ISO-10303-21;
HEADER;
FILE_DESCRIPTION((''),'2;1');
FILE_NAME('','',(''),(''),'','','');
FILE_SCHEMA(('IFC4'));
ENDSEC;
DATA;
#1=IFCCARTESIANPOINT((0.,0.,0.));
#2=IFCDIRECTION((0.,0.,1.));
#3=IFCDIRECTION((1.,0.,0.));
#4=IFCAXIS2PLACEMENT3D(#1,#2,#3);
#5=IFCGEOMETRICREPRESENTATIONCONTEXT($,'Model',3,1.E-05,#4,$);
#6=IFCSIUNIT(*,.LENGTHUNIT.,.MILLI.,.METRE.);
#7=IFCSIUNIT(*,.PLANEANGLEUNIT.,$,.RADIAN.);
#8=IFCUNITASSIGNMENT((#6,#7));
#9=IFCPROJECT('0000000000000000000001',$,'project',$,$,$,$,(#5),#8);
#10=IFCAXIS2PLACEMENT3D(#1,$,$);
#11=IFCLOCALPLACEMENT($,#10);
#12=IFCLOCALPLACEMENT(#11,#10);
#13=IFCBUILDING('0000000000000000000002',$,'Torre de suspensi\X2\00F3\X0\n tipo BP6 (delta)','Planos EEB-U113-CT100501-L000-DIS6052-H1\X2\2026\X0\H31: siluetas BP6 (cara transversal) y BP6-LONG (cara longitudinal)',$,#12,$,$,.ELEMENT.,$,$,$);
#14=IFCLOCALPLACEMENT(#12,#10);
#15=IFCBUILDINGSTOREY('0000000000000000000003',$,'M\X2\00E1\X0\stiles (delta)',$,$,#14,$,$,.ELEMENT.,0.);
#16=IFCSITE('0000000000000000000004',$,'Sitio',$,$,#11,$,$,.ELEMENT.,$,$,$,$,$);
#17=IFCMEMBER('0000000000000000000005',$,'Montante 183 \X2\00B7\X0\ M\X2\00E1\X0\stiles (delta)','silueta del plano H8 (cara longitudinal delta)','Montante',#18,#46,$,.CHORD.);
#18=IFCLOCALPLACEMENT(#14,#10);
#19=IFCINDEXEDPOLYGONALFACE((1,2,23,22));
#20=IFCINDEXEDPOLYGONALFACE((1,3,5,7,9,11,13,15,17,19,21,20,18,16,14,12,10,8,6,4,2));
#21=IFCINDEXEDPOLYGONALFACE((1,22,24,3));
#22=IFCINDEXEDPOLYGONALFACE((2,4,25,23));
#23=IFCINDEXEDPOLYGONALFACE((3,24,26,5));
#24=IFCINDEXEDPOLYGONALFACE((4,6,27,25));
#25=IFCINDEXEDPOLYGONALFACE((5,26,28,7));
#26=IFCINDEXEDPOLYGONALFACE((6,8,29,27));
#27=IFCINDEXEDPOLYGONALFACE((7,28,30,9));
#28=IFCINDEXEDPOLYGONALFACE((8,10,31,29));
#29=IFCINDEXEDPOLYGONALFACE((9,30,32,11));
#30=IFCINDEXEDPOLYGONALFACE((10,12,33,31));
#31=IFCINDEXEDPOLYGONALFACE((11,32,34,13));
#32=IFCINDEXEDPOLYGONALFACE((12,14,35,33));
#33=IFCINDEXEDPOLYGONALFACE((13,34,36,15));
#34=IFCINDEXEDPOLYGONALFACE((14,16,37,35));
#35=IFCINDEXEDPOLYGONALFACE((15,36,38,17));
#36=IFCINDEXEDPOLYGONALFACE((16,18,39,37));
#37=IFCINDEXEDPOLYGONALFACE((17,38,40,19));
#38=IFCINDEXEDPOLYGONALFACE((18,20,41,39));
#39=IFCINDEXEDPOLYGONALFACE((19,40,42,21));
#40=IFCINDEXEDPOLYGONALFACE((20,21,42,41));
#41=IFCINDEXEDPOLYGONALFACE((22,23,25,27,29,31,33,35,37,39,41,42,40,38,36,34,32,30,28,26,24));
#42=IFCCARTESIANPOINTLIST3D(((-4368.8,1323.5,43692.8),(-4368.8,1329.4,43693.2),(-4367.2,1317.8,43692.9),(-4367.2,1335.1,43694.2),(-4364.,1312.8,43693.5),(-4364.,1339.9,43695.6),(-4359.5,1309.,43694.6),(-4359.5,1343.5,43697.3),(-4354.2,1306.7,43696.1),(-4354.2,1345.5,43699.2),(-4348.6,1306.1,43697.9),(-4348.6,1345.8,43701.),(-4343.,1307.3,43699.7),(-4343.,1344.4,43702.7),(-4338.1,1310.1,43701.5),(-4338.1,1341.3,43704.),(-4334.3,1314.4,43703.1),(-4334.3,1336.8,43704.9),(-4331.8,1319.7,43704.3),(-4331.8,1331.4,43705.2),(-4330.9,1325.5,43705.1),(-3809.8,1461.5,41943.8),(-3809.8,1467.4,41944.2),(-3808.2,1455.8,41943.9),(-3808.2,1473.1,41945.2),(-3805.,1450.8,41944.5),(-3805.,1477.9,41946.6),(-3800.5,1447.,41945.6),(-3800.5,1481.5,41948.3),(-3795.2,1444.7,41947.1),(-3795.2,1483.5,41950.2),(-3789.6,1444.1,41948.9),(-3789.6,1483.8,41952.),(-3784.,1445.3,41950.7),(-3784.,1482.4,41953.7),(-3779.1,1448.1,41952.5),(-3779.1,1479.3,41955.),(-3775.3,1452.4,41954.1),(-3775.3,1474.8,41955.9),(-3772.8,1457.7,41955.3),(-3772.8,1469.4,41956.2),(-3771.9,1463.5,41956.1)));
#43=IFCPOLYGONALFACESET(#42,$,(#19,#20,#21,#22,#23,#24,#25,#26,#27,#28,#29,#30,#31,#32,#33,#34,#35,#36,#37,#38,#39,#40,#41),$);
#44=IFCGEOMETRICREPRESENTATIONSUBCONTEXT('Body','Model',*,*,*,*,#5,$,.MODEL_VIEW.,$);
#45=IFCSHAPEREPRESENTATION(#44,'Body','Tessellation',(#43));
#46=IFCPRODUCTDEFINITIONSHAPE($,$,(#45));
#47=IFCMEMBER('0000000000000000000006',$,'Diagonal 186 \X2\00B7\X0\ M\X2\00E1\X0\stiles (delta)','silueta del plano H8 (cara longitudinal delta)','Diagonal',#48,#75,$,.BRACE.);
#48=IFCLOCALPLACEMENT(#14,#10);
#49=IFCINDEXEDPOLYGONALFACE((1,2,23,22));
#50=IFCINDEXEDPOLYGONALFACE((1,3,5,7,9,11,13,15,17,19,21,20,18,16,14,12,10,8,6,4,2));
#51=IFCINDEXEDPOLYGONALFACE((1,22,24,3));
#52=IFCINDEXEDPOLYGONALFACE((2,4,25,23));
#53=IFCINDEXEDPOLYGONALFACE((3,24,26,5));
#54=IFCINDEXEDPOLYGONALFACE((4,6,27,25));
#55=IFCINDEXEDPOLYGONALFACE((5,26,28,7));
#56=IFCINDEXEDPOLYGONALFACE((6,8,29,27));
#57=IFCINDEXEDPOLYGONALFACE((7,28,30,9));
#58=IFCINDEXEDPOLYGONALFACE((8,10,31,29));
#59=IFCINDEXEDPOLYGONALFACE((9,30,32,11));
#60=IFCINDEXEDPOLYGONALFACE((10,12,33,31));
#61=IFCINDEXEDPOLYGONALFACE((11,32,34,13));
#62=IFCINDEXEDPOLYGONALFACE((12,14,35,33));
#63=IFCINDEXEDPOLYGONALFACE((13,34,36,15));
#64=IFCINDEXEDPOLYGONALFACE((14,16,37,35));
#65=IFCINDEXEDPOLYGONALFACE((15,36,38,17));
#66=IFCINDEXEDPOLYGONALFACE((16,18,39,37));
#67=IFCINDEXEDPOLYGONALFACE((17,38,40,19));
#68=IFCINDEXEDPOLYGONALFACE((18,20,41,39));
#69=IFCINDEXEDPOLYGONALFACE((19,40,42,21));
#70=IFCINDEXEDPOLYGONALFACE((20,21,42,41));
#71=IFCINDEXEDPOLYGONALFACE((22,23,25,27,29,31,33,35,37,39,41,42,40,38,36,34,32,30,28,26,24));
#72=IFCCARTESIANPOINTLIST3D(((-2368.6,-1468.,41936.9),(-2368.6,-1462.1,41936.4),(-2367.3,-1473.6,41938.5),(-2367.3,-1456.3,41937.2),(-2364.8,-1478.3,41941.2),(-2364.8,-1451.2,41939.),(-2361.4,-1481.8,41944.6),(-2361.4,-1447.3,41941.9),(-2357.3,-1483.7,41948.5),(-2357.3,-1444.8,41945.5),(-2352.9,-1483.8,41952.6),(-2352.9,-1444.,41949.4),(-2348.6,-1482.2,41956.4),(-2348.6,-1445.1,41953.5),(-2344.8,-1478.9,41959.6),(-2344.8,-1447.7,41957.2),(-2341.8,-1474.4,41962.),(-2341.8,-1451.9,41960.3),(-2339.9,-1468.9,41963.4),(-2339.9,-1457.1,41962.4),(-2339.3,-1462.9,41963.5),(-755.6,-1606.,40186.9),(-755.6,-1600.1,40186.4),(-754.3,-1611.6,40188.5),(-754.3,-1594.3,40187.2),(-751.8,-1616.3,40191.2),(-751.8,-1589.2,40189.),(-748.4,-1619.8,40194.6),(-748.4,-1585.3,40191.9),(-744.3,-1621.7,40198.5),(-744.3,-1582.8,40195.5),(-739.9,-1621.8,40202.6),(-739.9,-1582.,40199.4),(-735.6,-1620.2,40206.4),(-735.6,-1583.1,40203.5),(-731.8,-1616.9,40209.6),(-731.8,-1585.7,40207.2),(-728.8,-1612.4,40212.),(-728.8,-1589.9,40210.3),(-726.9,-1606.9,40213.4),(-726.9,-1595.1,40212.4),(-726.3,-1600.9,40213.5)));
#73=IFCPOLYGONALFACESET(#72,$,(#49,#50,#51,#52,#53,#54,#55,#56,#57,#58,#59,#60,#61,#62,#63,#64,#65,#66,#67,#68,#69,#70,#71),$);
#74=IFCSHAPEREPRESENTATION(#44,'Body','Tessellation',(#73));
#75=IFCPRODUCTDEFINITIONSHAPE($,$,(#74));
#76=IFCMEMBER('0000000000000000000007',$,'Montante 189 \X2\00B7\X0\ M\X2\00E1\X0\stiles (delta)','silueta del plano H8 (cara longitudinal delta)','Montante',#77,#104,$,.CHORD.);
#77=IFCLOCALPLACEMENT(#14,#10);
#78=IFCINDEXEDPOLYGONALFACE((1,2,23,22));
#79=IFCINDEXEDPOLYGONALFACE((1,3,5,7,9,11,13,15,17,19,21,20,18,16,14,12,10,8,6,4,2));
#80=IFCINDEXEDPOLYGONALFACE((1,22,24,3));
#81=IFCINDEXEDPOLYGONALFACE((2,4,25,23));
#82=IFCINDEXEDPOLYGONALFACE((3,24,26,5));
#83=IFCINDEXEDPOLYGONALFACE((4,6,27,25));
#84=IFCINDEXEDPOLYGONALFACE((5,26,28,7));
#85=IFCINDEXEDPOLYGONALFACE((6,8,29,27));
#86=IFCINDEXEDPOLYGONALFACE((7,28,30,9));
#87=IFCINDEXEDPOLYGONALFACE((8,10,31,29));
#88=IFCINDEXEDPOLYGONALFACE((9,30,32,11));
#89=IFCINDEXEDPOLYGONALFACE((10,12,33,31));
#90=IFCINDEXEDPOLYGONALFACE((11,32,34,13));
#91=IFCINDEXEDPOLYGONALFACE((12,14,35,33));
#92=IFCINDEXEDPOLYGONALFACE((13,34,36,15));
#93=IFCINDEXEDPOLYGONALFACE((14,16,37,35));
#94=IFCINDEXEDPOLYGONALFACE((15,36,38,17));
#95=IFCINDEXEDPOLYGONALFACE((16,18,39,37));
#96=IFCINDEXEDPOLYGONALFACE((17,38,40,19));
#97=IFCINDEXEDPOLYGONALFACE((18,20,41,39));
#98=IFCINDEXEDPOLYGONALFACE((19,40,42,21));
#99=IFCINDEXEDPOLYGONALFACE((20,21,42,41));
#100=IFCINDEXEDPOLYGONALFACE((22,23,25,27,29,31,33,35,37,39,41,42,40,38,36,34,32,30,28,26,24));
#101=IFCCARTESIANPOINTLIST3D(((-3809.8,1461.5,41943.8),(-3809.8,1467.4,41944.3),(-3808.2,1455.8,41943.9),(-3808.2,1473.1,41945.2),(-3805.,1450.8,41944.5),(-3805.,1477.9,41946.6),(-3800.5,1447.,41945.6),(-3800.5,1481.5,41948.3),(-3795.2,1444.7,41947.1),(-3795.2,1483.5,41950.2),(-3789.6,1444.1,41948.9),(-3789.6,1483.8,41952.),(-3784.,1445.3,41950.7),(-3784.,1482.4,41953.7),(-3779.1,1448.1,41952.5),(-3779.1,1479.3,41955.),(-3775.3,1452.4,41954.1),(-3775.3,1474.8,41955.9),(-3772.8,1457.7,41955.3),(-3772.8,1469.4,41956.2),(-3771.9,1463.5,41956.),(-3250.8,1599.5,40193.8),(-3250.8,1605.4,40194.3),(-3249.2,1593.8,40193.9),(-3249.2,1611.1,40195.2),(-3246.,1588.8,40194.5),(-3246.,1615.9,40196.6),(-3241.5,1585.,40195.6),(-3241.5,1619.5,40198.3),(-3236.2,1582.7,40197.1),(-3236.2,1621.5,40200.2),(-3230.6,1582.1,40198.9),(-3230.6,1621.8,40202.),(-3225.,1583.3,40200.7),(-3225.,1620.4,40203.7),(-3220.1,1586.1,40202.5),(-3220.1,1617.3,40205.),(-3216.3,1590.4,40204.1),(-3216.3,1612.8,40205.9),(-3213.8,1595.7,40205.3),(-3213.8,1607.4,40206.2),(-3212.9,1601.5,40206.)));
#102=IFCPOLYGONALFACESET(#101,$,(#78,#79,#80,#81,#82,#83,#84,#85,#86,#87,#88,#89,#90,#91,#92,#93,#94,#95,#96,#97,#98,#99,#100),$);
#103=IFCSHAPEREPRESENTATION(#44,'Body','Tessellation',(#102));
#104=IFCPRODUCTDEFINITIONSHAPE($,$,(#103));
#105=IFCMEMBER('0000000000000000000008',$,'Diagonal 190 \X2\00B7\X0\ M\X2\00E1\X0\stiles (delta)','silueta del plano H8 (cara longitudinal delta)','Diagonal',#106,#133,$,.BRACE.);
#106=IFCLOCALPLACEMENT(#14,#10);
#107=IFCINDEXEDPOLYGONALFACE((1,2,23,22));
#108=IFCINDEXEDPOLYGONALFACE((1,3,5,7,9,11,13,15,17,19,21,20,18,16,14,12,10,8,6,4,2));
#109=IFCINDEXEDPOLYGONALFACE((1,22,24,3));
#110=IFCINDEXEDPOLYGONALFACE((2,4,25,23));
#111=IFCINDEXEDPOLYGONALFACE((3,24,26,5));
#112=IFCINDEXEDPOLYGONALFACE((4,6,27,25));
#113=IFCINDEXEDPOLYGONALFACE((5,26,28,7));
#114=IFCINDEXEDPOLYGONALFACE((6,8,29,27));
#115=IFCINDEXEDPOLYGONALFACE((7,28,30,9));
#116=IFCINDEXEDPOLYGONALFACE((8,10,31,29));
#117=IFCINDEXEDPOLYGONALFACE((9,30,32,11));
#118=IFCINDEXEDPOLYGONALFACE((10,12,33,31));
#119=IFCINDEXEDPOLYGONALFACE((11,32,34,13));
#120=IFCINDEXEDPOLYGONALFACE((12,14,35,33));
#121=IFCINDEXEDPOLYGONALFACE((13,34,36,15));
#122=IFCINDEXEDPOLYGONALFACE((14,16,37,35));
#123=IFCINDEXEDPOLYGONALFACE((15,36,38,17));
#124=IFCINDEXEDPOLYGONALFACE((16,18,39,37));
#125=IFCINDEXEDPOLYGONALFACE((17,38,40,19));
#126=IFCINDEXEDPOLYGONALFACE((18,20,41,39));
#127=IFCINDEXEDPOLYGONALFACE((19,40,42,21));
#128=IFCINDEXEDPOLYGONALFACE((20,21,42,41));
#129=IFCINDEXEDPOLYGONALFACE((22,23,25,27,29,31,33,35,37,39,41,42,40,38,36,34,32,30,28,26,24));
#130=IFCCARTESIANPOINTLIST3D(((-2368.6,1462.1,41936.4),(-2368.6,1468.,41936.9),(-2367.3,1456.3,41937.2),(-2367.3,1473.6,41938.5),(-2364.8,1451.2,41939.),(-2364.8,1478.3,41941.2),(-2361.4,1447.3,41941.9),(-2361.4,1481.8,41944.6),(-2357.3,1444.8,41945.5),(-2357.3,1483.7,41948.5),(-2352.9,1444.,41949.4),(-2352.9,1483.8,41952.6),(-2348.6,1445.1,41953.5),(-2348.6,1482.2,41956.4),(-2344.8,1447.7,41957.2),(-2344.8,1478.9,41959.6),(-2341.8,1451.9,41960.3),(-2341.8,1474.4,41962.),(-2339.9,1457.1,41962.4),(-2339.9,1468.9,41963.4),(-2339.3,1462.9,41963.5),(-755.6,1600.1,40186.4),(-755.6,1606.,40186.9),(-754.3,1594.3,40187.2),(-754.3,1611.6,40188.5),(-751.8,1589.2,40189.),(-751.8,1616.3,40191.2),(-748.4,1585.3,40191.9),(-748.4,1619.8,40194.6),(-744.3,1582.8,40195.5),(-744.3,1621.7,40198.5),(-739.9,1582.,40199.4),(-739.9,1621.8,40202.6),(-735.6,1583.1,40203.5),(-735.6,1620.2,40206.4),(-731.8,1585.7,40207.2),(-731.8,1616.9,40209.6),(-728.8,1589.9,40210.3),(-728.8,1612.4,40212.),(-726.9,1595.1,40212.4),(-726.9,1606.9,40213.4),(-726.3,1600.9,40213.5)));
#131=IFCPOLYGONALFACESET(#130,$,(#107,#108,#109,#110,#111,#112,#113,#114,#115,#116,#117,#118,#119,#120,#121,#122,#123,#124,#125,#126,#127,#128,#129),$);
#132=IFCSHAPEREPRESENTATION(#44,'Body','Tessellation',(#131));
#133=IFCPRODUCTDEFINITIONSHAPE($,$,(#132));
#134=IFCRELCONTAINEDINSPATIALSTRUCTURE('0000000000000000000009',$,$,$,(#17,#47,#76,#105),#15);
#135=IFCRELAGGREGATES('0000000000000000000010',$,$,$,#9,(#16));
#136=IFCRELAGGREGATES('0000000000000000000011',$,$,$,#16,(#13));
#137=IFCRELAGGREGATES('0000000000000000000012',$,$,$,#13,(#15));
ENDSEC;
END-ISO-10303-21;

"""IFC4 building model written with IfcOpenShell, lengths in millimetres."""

from ifc_helpers import new_model, si_unit, frame, origin, origin_with_axes, place, context, subcontext, project, spatial, circle, extrude, element, save


model = new_model("IFC4")

# Units and contexts
model_context = context("Model", 3, precision=1e-05, world=origin_with_axes())
body_context = subcontext(model_context, "Body", "Model", "MODEL_VIEW")
ifc_project = project(units=[si_unit("LENGTHUNIT", "METRE", prefix="MILLI"), si_unit("PLANEANGLEUNIT", "RADIAN")], contexts=[model_context])

# Site, building, storey
site_placement = place(None, origin())
site = spatial("IfcSite", under=ifc_project, at=site_placement, Name="Sitio", CompositionType="ELEMENT")
building_placement = place(site_placement, origin())
building = spatial("IfcBuilding", under=site, at=building_placement, Name="Torre de suspensión tipo BP6 (delta)", Description="Planos EEB-U113-CT100501-L000-DIS6052-H1…H31: siluetas BP6 (cara transversal) y BP6-LONG (cara longitudinal)", CompositionType="ELEMENT")
storey_placement = place(building_placement, origin())
storey = spatial("IfcBuildingStorey", under=building, at=storey_placement, Name="Mástiles (delta)", CompositionType="ELEMENT", Elevation=0.0)

# Members
for number, where, z_axis, x_axis, name in (
    (1, (-4350.0, 1326.0, 43699.0), (0.303584, 0.074945, -0.949853), (0.952805, -0.023879, 0.302643), "Montante 183 · Mástiles (delta)"),
):
    element("IfcMember", number, at=place(storey_placement, frame(where, z_axis=z_axis, x_axis=x_axis)), inside=storey, Name=name, Description="silueta del plano H8 (cara longitudinal delta)", ObjectType="Montante", PredefinedType="CHORD", context=body_context, shape_type="SweptSolid", body=[
        extrude(circle(Radius=20.0), None, (0.0, 0.0, 1.0), 1841.3),
    ])
member_1_placement = place(storey_placement, frame((-2354.0, -1464.0, 41950.0), z_axis=(0.676602, -0.057887, -0.73407), x_axis=(0.736348, 0.05319, 0.674509)))
element("IfcMember", 2, at=member_1_placement, inside=storey, Name="Diagonal 186 · Mástiles (delta)", Description="silueta del plano H8 (cara longitudinal delta)", ObjectType="Diagonal", PredefinedType="BRACE", context=body_context, shape_type="SweptSolid", body=[
    extrude(circle(Radius=20.0), None, (0.0, 0.0, 1.0), 2384.0),
])
member_2_placement = place(storey_placement, frame((-3791.0, 1464.0, 41950.0), z_axis=(0.303427, 0.074907, -0.949906), x_axis=(0.952855, -0.023853, 0.302488)))
element("IfcMember", 3, at=member_2_placement, inside=storey, Name="Montante 189 · Mástiles (delta)", Description="silueta del plano H8 (cara longitudinal delta)", ObjectType="Montante", PredefinedType="CHORD", context=body_context, shape_type="SweptSolid", body=[
    extrude(circle(Radius=20.0), None, (0.0, 0.0, 1.0), 1842.3),
])
member_3_placement = place(storey_placement, frame((-2354.0, 1464.0, 41950.0), z_axis=(0.676602, 0.057887, -0.73407), x_axis=(0.736348, -0.05319, 0.674509)))
element("IfcMember", 4, at=member_3_placement, inside=storey, Name="Diagonal 190 · Mástiles (delta)", Description="silueta del plano H8 (cara longitudinal delta)", ObjectType="Diagonal", PredefinedType="BRACE", context=body_context, shape_type="SweptSolid", body=[
    extrude(circle(Radius=20.0), None, (0.0, 0.0, 1.0), 2384.0),
])

save(model, "model.ifc")
